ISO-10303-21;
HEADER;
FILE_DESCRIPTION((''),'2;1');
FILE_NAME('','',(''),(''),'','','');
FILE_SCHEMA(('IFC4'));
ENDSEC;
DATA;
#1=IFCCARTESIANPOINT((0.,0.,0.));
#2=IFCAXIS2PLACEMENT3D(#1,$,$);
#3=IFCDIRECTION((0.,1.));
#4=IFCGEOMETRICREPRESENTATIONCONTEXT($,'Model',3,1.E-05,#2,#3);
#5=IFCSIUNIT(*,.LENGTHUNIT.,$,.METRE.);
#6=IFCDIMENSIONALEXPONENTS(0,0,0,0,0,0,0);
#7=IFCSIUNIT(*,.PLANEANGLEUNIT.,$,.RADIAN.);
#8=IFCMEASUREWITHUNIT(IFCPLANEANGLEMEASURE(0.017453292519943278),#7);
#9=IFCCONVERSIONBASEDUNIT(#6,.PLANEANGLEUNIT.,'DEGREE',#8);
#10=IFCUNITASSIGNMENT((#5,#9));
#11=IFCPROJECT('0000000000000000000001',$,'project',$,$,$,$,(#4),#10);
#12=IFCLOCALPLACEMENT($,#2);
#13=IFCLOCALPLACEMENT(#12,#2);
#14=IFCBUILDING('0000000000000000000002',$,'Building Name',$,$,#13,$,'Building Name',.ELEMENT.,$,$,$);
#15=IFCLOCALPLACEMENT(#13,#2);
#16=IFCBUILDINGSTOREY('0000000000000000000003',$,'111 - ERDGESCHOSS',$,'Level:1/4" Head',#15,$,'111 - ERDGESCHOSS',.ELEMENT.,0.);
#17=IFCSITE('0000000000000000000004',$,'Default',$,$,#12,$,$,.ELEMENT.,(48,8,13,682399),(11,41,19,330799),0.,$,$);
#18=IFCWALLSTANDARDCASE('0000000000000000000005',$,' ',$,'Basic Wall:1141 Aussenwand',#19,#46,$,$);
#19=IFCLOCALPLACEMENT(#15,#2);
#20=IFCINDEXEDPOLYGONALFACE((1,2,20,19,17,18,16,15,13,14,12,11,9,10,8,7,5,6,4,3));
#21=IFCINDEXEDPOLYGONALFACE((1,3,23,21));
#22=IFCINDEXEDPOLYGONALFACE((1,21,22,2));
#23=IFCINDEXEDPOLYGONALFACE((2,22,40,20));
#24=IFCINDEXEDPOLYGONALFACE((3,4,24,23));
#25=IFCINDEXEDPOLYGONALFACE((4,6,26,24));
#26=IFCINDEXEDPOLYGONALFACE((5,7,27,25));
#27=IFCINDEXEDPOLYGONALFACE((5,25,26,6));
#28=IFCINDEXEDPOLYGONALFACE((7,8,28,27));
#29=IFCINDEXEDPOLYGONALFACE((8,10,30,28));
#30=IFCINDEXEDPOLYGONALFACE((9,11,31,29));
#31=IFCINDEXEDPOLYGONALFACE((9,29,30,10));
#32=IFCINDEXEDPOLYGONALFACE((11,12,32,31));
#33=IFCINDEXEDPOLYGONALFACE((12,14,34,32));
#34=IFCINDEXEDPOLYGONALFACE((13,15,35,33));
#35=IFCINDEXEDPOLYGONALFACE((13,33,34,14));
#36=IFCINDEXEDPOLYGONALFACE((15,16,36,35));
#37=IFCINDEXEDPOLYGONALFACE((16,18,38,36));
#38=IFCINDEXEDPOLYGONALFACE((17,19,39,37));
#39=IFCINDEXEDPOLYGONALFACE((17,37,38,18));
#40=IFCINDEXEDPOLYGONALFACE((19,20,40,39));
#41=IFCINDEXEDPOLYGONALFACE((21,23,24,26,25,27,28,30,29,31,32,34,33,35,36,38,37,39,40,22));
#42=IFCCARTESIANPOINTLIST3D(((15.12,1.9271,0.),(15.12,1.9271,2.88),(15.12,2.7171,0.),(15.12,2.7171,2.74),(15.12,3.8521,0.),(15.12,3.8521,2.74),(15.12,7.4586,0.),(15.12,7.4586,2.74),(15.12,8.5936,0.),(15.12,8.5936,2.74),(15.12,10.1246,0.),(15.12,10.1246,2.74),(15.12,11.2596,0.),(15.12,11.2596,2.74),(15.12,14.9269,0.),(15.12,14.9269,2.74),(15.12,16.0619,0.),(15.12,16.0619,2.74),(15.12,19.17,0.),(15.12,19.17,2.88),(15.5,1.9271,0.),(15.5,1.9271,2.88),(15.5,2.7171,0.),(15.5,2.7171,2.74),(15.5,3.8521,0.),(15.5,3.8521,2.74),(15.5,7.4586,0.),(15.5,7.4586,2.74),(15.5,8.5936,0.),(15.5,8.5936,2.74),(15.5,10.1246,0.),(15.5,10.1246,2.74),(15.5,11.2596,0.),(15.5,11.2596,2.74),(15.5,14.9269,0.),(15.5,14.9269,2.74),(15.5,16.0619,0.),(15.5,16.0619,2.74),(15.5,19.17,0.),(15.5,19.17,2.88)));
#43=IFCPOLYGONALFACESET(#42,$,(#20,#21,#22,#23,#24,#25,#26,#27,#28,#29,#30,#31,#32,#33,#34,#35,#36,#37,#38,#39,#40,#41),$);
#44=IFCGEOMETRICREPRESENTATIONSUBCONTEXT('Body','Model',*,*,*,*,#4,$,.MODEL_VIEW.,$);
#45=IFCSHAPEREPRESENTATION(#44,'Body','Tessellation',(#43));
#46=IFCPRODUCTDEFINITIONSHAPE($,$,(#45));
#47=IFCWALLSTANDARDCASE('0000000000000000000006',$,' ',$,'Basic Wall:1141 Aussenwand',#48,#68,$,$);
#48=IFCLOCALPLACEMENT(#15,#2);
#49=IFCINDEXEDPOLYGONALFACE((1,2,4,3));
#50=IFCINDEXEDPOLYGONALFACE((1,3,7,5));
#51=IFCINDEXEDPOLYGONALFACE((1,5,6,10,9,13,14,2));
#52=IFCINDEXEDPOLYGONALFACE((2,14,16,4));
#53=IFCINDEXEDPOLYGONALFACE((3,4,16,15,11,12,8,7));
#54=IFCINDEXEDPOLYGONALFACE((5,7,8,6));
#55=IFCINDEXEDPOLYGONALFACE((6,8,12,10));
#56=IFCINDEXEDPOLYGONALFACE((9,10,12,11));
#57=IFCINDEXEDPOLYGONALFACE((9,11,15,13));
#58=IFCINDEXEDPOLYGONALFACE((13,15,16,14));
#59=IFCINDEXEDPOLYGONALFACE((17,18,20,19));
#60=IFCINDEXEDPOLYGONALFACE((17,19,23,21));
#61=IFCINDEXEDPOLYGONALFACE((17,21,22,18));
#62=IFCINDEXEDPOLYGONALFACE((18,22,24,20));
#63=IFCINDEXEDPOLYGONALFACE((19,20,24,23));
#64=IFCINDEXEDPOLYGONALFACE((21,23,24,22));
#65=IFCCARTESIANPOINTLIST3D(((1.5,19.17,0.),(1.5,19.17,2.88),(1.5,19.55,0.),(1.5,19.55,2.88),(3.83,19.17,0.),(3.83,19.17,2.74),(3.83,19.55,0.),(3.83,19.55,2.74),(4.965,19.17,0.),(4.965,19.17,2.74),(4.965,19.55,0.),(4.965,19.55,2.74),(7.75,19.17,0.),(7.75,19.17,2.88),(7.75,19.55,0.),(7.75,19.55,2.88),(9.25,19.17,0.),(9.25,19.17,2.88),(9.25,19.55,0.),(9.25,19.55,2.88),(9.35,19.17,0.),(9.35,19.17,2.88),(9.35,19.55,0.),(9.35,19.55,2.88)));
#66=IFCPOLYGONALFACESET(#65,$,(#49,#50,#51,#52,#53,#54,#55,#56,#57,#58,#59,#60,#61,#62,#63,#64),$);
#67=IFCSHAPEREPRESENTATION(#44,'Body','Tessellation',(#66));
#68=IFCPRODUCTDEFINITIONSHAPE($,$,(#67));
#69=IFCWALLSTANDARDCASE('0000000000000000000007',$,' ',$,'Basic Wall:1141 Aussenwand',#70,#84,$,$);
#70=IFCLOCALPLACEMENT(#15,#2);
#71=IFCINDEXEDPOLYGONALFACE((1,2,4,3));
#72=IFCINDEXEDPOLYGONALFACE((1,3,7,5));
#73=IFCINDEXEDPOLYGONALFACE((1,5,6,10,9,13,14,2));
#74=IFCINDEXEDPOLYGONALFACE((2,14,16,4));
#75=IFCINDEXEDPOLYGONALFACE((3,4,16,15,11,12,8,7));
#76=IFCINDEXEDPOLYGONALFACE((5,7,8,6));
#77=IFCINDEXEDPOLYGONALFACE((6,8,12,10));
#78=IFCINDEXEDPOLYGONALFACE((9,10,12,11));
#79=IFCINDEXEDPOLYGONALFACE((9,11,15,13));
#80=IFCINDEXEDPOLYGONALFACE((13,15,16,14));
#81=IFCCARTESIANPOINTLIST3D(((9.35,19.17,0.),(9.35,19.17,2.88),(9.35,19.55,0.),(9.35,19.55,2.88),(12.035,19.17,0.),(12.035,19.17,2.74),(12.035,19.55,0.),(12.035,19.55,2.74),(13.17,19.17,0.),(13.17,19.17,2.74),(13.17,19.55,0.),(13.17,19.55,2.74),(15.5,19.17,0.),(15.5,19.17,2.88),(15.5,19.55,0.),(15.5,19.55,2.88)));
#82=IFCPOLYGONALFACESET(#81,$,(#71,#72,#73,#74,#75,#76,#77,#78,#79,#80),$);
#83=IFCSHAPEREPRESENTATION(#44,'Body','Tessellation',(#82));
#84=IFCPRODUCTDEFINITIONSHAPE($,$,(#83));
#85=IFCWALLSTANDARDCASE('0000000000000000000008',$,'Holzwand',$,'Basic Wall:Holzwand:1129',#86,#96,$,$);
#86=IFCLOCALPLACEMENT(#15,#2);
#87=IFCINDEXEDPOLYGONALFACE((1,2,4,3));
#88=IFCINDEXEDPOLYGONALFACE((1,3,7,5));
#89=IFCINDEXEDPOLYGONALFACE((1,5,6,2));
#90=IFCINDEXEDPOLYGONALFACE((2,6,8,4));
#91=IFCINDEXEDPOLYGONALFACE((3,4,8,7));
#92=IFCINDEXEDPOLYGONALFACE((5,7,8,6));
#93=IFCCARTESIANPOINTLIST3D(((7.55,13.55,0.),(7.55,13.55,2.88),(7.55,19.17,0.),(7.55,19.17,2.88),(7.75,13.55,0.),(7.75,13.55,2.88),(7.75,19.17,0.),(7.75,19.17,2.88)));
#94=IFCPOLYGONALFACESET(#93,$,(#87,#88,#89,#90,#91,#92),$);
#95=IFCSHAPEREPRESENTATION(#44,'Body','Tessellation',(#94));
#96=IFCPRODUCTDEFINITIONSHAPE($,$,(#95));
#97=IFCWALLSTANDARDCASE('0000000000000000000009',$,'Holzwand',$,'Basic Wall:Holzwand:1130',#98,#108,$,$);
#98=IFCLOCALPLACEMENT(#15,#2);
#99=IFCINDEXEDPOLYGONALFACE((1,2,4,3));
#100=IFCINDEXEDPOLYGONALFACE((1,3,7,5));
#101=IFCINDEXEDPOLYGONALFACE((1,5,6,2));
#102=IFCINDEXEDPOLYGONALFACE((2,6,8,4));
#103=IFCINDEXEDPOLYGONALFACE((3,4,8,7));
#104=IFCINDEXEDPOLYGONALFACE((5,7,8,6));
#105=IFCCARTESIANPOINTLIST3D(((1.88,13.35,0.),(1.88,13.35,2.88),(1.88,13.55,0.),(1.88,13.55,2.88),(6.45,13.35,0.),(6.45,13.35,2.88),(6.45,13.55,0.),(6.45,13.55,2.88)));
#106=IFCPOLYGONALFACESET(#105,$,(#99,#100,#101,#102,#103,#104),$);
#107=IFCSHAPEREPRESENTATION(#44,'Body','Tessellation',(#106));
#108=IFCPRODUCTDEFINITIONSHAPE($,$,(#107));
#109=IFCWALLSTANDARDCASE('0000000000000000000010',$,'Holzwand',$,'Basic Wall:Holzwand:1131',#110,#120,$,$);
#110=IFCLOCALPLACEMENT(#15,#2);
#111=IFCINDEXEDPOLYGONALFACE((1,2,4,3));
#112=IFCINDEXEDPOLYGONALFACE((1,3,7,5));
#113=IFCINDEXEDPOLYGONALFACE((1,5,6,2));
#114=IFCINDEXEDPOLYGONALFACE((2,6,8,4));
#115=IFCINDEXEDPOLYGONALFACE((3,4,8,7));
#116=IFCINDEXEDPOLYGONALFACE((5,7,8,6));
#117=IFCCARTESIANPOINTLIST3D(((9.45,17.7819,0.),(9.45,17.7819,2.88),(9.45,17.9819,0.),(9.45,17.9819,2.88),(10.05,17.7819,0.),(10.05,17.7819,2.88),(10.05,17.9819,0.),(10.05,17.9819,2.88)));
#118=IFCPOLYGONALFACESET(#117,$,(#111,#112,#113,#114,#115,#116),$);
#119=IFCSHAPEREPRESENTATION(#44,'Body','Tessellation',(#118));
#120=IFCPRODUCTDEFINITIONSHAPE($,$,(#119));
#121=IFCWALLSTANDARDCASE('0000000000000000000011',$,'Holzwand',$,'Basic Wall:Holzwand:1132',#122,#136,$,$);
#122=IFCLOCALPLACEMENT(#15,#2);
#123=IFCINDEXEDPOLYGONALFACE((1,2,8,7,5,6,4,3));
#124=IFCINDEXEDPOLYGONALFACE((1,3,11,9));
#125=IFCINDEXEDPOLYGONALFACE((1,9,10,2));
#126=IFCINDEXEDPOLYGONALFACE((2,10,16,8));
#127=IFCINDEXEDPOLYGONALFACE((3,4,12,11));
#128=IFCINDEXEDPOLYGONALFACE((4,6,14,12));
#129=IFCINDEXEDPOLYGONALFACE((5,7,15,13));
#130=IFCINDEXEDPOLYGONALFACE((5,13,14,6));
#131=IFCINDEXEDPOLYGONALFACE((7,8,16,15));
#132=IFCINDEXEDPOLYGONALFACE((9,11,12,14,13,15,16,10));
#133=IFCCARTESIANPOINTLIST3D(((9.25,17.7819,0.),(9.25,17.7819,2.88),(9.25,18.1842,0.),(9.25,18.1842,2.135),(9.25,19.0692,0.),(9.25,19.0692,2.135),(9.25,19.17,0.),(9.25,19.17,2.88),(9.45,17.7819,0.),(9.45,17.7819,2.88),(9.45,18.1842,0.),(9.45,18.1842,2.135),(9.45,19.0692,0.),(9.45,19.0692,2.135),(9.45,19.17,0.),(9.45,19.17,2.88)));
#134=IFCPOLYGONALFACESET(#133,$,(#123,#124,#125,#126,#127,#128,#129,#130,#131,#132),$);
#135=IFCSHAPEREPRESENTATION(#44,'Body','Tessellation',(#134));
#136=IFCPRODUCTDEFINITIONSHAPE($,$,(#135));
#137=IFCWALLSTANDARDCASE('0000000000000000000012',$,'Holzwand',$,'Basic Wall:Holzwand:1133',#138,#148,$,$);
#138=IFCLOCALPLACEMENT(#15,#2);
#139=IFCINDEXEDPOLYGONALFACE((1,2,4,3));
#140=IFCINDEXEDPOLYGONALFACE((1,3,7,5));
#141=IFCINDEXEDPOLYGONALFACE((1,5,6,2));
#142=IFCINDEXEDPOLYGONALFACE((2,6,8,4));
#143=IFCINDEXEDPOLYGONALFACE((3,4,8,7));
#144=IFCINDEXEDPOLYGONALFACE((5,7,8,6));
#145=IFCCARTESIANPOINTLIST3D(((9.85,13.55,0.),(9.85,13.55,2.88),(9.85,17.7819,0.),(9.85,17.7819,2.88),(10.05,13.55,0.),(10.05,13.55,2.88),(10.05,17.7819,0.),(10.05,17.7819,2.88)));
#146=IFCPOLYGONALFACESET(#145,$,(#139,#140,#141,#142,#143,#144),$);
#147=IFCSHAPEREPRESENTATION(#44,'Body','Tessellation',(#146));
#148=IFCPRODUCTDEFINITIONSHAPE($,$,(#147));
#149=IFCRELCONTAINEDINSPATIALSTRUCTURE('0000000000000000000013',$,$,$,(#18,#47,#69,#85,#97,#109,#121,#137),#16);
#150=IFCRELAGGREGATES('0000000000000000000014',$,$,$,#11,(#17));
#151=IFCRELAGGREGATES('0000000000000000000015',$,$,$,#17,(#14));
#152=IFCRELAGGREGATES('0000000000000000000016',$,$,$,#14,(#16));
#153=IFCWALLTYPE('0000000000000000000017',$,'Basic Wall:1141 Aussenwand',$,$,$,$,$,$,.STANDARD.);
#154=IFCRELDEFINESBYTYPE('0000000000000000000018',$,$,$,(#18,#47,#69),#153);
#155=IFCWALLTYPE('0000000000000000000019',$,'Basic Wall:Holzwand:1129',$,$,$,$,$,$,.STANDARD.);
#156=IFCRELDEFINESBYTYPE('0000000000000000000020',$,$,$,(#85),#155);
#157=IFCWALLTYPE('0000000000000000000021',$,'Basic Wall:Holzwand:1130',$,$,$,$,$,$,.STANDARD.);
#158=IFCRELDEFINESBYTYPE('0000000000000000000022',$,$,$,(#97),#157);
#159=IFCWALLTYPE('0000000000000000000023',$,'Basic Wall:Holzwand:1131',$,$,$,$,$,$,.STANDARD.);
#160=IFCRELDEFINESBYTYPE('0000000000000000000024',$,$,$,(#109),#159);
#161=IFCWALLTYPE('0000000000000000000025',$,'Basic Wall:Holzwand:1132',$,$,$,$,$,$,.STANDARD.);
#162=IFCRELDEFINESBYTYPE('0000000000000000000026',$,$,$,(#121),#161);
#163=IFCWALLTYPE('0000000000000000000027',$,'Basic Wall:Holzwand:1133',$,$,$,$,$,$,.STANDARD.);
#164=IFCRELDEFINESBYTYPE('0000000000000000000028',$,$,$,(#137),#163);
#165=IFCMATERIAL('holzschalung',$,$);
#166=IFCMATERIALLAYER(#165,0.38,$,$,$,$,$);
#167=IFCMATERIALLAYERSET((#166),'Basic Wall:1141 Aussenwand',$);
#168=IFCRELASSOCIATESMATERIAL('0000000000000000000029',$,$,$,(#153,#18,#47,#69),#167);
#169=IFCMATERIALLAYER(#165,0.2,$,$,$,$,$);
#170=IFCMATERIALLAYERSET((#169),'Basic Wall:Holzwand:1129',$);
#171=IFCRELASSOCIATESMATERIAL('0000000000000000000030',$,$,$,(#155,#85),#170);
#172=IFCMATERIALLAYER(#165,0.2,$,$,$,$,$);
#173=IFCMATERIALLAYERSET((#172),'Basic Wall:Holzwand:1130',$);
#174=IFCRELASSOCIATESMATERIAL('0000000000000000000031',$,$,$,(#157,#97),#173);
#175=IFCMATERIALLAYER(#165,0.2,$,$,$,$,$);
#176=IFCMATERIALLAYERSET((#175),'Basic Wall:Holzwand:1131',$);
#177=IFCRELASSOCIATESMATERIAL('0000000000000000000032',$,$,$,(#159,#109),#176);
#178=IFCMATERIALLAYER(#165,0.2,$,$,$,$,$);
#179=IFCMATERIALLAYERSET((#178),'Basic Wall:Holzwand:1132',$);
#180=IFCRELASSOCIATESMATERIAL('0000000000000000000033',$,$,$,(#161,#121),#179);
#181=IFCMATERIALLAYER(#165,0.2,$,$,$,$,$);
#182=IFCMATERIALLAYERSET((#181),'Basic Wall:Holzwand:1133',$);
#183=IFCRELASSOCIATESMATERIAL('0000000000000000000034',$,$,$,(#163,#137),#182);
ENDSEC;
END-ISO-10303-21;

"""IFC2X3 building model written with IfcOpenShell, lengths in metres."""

from ifc_helpers import new_model, entity, si_unit, converted_unit, direction, frame, frame_2d, origin, origin_2d_with_axis, place, context, subcontext, project, spatial, rectangle, extrude, material, layer, layer_set, layer_usage, type_object, element, save


model = new_model("IFC2X3")

# Units and contexts
model_context = context("Model", 3, precision=1e-05, world=origin(), true_north=direction((0.0, 1.0)))
body_context = subcontext(model_context, "Body", "Model", "MODEL_VIEW")
ifc_project = project(units=[si_unit("LENGTHUNIT", "METRE"), converted_unit("PLANEANGLEUNIT", "DEGREE", entity("IfcPlaneAngleMeasure", 0.017453292519943278), si_unit("PLANEANGLEUNIT", "RADIAN"), dimensions=[0, 0, 0, 0, 0, 0, 0])], contexts=[model_context])

# Site, building, storey
site_placement = place(None, origin())
site = spatial("IfcSite", under=ifc_project, at=site_placement, Name="Default", CompositionType="ELEMENT", RefLatitude=(48, 8, 13, 682399), RefLongitude=(11, 41, 19, 330799), RefElevation=0.0)
building_placement = place(site_placement, origin())
building = spatial("IfcBuilding", under=site, at=building_placement, Name="Building Name", LongName="Building Name", CompositionType="ELEMENT")
storey_placement = place(building_placement, origin())
storey = spatial("IfcBuildingStorey", under=building, at=storey_placement, Name="111 - ERDGESCHOSS", ObjectType="Level:1/4\" Head", LongName="111 - ERDGESCHOSS", CompositionType="ELEMENT", Elevation=0.0)

# Walls, openings
ifc_material_1 = material(Name="holzschalung")
ifc_layer_1 = layer(ifc_material_1, 0.38)
ifc_layer_set_1 = layer_set([ifc_layer_1], Name="Basic Wall:1141 Aussenwand")
ifc_layer_usage_1 = layer_usage(ifc_layer_set_1, "AXIS2", "NEGATIVE", 0.19)
wall_type_1 = type_object("IfcWallType", Name="Basic Wall:1141 Aussenwand", PredefinedType="STANDARD", material=ifc_layer_set_1)
wall_1_placement = place(storey_placement, frame((15.31, 19.17, 0.0), z_axis=(0.0, 0.0, 1.0), x_axis=(0.0, -1.0, 0.0)))
wall_1 = element("IfcWallStandardCase", 1, at=wall_1_placement, inside=storey, type_object=wall_type_1, material=ifc_layer_usage_1, Name=" ", ObjectType="Basic Wall:1141 Aussenwand", context=body_context, shape_type="SweptSolid", body=[
    extrude(rectangle(XDim=17.2429, YDim=0.38, at=frame_2d((8.6214, 0.0), x_axis=(-1.0, 0.0))), origin(), (0.0, 0.0, 1.0), 2.88),
])
opening_1_placement = place(wall_1_placement, origin())
element("IfcOpeningElement", 2, at=opening_1_placement, cuts=wall_1, ObjectType="Opening", context=body_context, shape_type="SweptSolid", body=[
    extrude(rectangle(XDim=2.74, YDim=1.135, at=frame_2d((0.0, 0.0), x_axis=(0.0, 1.0))), frame((15.8854, -0.19, 1.37), z_axis=(0.0, 1.0, 0.0), x_axis=(-1.0, 0.0, 0.0)), (0.0, 0.0, 1.0), 0.38),
])
opening_2_placement = place(wall_1_placement, origin())
element("IfcOpeningElement", 3, at=opening_2_placement, cuts=wall_1, ObjectType="Opening", context=body_context, shape_type="SweptSolid", body=[
    extrude(rectangle(XDim=2.74, YDim=1.135, at=frame_2d((0.0, 0.0), x_axis=(0.0, 1.0))), frame((11.1439, -0.19, 1.37), z_axis=(0.0, 1.0, 0.0), x_axis=(-1.0, 0.0, 0.0)), (0.0, 0.0, 1.0), 0.38),
])
opening_3_placement = place(wall_1_placement, origin())
element("IfcOpeningElement", 4, at=opening_3_placement, cuts=wall_1, ObjectType="Opening", context=body_context, shape_type="SweptSolid", body=[
    extrude(rectangle(XDim=2.74, YDim=1.135, at=frame_2d((0.0, 0.0), x_axis=(0.0, 1.0))), frame((8.4779, -0.19, 1.37), z_axis=(0.0, 1.0, 0.0), x_axis=(-1.0, 0.0, 0.0)), (0.0, 0.0, 1.0), 0.38),
])
opening_4_placement = place(wall_1_placement, origin())
element("IfcOpeningElement", 5, at=opening_4_placement, cuts=wall_1, ObjectType="Opening", context=body_context, shape_type="SweptSolid", body=[
    extrude(rectangle(XDim=2.74, YDim=1.135, at=frame_2d((0.0, 0.0), x_axis=(0.0, 1.0))), frame((3.6756, -0.19, 1.37), z_axis=(0.0, 1.0, 0.0), x_axis=(-1.0, 0.0, 0.0)), (0.0, 0.0, 1.0), 0.38),
])
ifc_layer_usage_2 = layer_usage(ifc_layer_set_1, "AXIS2", "NEGATIVE", 0.19)
wall_2_placement = place(storey_placement, frame((1.5, 19.36, 0.0)))
wall_2 = element("IfcWallStandardCase", 6, at=wall_2_placement, inside=storey, type_object=wall_type_1, material=ifc_layer_usage_2, Name=" ", ObjectType="Basic Wall:1141 Aussenwand", context=body_context, shape_type="SweptSolid", body=[
    extrude(rectangle(XDim=7.85, YDim=0.38, at=frame_2d((3.925, 0.0), x_axis=(-1.0, 0.0))), origin(), (0.0, 0.0, 1.0), 2.88),
])
opening_5_placement = place(wall_2_placement, origin())
element("IfcOpeningElement", 7, at=opening_5_placement, cuts=wall_2, ObjectType="Opening", context=body_context, shape_type="SweptSolid", body=[
    extrude(rectangle(XDim=2.74, YDim=1.135, at=frame_2d((0.0, 0.0), x_axis=(1.0, 0.0))), frame((2.8975, -0.19, 1.37), z_axis=(0.0, 1.0, 0.0), x_axis=(0.0, 0.0, 1.0)), (0.0, 0.0, 1.0), 0.38),
])
opening_6_placement = place(wall_2_placement, frame((-1.5, -19.36, 0.0)))
element("IfcOpeningElement", 8, at=opening_6_placement, cuts=wall_2, ObjectType="Opening", context=body_context, shape_type="SweptSolid", body=[
    extrude(rectangle(XDim=3.03, YDim=1.5, at=frame_2d((0.0, 0.0), x_axis=(0.0, 1.0))), frame((8.5, 19.1662, 1.365), z_axis=(0.0, 1.0, 0.0), x_axis=(-1.0, 0.0, 0.0)), (0.0, 0.0, 1.0), 0.3876),
])

# Wall, opening
ifc_layer_usage_3 = layer_usage(ifc_layer_set_1, "AXIS2", "NEGATIVE", 0.19)
wall_3_placement = place(storey_placement, frame((9.35, 19.36, 0.0)))
wall_3 = element("IfcWallStandardCase", 9, at=wall_3_placement, inside=storey, type_object=wall_type_1, material=ifc_layer_usage_3, Name=" ", ObjectType="Basic Wall:1141 Aussenwand", context=body_context, shape_type="SweptSolid", body=[
    extrude(rectangle(XDim=6.15, YDim=0.38, at=frame_2d((3.075, 0.0), x_axis=(-1.0, 0.0))), origin(), (0.0, 0.0, 1.0), 2.88),
])
opening_7_placement = place(wall_3_placement, origin())
element("IfcOpeningElement", 10, at=opening_7_placement, cuts=wall_3, ObjectType="Opening", context=body_context, shape_type="SweptSolid", body=[
    extrude(rectangle(XDim=2.74, YDim=1.135, at=origin_2d_with_axis()), frame((3.2525, -0.19, 1.37), z_axis=(0.0, 1.0, 0.0), x_axis=(0.0, 0.0, 1.0)), (0.0, 0.0, 1.0), 0.38),
])

# Walls
ifc_layer_2 = layer(ifc_material_1, 0.2)
ifc_layer_set_2 = layer_set([ifc_layer_2], Name="Basic Wall:Holzwand:1129")
ifc_layer_usage_4 = layer_usage(ifc_layer_set_2, "AXIS2", "NEGATIVE", 0.1)
wall_type_2 = type_object("IfcWallType", Name="Basic Wall:Holzwand:1129", PredefinedType="STANDARD", material=ifc_layer_set_2)
wall_4_placement = place(storey_placement, frame((7.65, 13.55, 0.0), z_axis=(0.0, 0.0, 1.0), x_axis=(0.0, 1.0, 0.0)))
element("IfcWallStandardCase", 11, at=wall_4_placement, inside=storey, type_object=wall_type_2, material=ifc_layer_usage_4, Name="Holzwand", ObjectType="Basic Wall:Holzwand:1129", context=body_context, shape_type="SweptSolid", body=[
    extrude(rectangle(XDim=5.62, YDim=0.2, at=frame_2d((2.81, 0.0), x_axis=(-1.0, 0.0))), origin(), (0.0, 0.0, 1.0), 2.88),
])
ifc_layer_3 = layer(ifc_material_1, 0.2)
ifc_layer_set_3 = layer_set([ifc_layer_3], Name="Basic Wall:Holzwand:1130")
ifc_layer_usage_5 = layer_usage(ifc_layer_set_3, "AXIS2", "NEGATIVE", 0.1)
wall_type_3 = type_object("IfcWallType", Name="Basic Wall:Holzwand:1130", PredefinedType="STANDARD", material=ifc_layer_set_3)
wall_5_placement = place(storey_placement, frame((1.88, 13.45, 0.0)))
element("IfcWallStandardCase", 12, at=wall_5_placement, inside=storey, type_object=wall_type_3, material=ifc_layer_usage_5, Name="Holzwand", ObjectType="Basic Wall:Holzwand:1130", context=body_context, shape_type="SweptSolid", body=[
    extrude(rectangle(XDim=4.57, YDim=0.2, at=frame_2d((2.285, 0.0), x_axis=(-1.0, 0.0))), origin(), (0.0, 0.0, 1.0), 2.88),
])
ifc_layer_4 = layer(ifc_material_1, 0.2)
ifc_layer_set_4 = layer_set([ifc_layer_4], Name="Basic Wall:Holzwand:1131")
ifc_layer_usage_6 = layer_usage(ifc_layer_set_4, "AXIS2", "NEGATIVE", 0.1)
wall_type_4 = type_object("IfcWallType", Name="Basic Wall:Holzwand:1131", PredefinedType="STANDARD", material=ifc_layer_set_4)
wall_6_placement = place(storey_placement, frame((10.05, 17.8819, 0.0), z_axis=(0.0, 0.0, 1.0), x_axis=(-1.0, 0.0, 0.0)))
element("IfcWallStandardCase", 13, at=wall_6_placement, inside=storey, type_object=wall_type_4, material=ifc_layer_usage_6, Name="Holzwand", ObjectType="Basic Wall:Holzwand:1131", context=body_context, shape_type="SweptSolid", body=[
    extrude(rectangle(XDim=0.6, YDim=0.2, at=frame_2d((0.3, 0.0), x_axis=(-1.0, 0.0))), origin(), (0.0, 0.0, 1.0), 2.88),
])

# Wall, opening
ifc_layer_5 = layer(ifc_material_1, 0.2)
ifc_layer_set_5 = layer_set([ifc_layer_5], Name="Basic Wall:Holzwand:1132")
ifc_layer_usage_7 = layer_usage(ifc_layer_set_5, "AXIS2", "NEGATIVE", 0.1)
wall_type_5 = type_object("IfcWallType", Name="Basic Wall:Holzwand:1132", PredefinedType="STANDARD", material=ifc_layer_set_5)
wall_7_placement = place(storey_placement, frame((9.35, 17.7819, 0.0), z_axis=(0.0, 0.0, 1.0), x_axis=(0.0, 1.0, 0.0)))
wall_7 = element("IfcWallStandardCase", 14, at=wall_7_placement, inside=storey, type_object=wall_type_5, material=ifc_layer_usage_7, Name="Holzwand", ObjectType="Basic Wall:Holzwand:1132", context=body_context, shape_type="SweptSolid", body=[
    extrude(rectangle(XDim=1.3881, YDim=0.2, at=frame_2d((0.6941, 0.0), x_axis=(-1.0, 0.0))), origin(), (0.0, 0.0, 1.0), 2.88),
])
opening_8_placement = place(wall_7_placement, frame((-17.7819, 9.35, 0.0), z_axis=(0.0, 0.0, 1.0), x_axis=(0.0, -1.0, 0.0)))
element("IfcOpeningElement", 15, at=opening_8_placement, cuts=wall_7, ObjectType="Opening", context=body_context, shape_type="SweptSolid", body=[
    extrude(rectangle(XDim=2.135, YDim=0.885, at=frame_2d((0.0, 0.0), x_axis=(1.0, 0.0))), frame((9.452, 18.6267, 1.0675), z_axis=(-1.0, 0.0, 0.0), x_axis=(0.0, 0.0, 1.0)), (0.0, 0.0, 1.0), 0.204),
])

# Wall
ifc_layer_6 = layer(ifc_material_1, 0.2)
ifc_layer_set_6 = layer_set([ifc_layer_6], Name="Basic Wall:Holzwand:1133")
ifc_layer_usage_8 = layer_usage(ifc_layer_set_6, "AXIS2", "NEGATIVE", 0.1)
wall_type_6 = type_object("IfcWallType", Name="Basic Wall:Holzwand:1133", PredefinedType="STANDARD", material=ifc_layer_set_6)
wall_8_placement = place(storey_placement, frame((9.95, 13.55, 0.0), z_axis=(0.0, 0.0, 1.0), x_axis=(0.0, 1.0, 0.0)))
element("IfcWallStandardCase", 16, at=wall_8_placement, inside=storey, type_object=wall_type_6, material=ifc_layer_usage_8, Name="Holzwand", ObjectType="Basic Wall:Holzwand:1133", context=body_context, shape_type="SweptSolid", body=[
    extrude(rectangle(XDim=4.2319, YDim=0.2, at=frame_2d((2.1159, 0.0), x_axis=(-1.0, 0.0))), origin(), (0.0, 0.0, 1.0), 2.88),
])

save(model, "model.ifc")
